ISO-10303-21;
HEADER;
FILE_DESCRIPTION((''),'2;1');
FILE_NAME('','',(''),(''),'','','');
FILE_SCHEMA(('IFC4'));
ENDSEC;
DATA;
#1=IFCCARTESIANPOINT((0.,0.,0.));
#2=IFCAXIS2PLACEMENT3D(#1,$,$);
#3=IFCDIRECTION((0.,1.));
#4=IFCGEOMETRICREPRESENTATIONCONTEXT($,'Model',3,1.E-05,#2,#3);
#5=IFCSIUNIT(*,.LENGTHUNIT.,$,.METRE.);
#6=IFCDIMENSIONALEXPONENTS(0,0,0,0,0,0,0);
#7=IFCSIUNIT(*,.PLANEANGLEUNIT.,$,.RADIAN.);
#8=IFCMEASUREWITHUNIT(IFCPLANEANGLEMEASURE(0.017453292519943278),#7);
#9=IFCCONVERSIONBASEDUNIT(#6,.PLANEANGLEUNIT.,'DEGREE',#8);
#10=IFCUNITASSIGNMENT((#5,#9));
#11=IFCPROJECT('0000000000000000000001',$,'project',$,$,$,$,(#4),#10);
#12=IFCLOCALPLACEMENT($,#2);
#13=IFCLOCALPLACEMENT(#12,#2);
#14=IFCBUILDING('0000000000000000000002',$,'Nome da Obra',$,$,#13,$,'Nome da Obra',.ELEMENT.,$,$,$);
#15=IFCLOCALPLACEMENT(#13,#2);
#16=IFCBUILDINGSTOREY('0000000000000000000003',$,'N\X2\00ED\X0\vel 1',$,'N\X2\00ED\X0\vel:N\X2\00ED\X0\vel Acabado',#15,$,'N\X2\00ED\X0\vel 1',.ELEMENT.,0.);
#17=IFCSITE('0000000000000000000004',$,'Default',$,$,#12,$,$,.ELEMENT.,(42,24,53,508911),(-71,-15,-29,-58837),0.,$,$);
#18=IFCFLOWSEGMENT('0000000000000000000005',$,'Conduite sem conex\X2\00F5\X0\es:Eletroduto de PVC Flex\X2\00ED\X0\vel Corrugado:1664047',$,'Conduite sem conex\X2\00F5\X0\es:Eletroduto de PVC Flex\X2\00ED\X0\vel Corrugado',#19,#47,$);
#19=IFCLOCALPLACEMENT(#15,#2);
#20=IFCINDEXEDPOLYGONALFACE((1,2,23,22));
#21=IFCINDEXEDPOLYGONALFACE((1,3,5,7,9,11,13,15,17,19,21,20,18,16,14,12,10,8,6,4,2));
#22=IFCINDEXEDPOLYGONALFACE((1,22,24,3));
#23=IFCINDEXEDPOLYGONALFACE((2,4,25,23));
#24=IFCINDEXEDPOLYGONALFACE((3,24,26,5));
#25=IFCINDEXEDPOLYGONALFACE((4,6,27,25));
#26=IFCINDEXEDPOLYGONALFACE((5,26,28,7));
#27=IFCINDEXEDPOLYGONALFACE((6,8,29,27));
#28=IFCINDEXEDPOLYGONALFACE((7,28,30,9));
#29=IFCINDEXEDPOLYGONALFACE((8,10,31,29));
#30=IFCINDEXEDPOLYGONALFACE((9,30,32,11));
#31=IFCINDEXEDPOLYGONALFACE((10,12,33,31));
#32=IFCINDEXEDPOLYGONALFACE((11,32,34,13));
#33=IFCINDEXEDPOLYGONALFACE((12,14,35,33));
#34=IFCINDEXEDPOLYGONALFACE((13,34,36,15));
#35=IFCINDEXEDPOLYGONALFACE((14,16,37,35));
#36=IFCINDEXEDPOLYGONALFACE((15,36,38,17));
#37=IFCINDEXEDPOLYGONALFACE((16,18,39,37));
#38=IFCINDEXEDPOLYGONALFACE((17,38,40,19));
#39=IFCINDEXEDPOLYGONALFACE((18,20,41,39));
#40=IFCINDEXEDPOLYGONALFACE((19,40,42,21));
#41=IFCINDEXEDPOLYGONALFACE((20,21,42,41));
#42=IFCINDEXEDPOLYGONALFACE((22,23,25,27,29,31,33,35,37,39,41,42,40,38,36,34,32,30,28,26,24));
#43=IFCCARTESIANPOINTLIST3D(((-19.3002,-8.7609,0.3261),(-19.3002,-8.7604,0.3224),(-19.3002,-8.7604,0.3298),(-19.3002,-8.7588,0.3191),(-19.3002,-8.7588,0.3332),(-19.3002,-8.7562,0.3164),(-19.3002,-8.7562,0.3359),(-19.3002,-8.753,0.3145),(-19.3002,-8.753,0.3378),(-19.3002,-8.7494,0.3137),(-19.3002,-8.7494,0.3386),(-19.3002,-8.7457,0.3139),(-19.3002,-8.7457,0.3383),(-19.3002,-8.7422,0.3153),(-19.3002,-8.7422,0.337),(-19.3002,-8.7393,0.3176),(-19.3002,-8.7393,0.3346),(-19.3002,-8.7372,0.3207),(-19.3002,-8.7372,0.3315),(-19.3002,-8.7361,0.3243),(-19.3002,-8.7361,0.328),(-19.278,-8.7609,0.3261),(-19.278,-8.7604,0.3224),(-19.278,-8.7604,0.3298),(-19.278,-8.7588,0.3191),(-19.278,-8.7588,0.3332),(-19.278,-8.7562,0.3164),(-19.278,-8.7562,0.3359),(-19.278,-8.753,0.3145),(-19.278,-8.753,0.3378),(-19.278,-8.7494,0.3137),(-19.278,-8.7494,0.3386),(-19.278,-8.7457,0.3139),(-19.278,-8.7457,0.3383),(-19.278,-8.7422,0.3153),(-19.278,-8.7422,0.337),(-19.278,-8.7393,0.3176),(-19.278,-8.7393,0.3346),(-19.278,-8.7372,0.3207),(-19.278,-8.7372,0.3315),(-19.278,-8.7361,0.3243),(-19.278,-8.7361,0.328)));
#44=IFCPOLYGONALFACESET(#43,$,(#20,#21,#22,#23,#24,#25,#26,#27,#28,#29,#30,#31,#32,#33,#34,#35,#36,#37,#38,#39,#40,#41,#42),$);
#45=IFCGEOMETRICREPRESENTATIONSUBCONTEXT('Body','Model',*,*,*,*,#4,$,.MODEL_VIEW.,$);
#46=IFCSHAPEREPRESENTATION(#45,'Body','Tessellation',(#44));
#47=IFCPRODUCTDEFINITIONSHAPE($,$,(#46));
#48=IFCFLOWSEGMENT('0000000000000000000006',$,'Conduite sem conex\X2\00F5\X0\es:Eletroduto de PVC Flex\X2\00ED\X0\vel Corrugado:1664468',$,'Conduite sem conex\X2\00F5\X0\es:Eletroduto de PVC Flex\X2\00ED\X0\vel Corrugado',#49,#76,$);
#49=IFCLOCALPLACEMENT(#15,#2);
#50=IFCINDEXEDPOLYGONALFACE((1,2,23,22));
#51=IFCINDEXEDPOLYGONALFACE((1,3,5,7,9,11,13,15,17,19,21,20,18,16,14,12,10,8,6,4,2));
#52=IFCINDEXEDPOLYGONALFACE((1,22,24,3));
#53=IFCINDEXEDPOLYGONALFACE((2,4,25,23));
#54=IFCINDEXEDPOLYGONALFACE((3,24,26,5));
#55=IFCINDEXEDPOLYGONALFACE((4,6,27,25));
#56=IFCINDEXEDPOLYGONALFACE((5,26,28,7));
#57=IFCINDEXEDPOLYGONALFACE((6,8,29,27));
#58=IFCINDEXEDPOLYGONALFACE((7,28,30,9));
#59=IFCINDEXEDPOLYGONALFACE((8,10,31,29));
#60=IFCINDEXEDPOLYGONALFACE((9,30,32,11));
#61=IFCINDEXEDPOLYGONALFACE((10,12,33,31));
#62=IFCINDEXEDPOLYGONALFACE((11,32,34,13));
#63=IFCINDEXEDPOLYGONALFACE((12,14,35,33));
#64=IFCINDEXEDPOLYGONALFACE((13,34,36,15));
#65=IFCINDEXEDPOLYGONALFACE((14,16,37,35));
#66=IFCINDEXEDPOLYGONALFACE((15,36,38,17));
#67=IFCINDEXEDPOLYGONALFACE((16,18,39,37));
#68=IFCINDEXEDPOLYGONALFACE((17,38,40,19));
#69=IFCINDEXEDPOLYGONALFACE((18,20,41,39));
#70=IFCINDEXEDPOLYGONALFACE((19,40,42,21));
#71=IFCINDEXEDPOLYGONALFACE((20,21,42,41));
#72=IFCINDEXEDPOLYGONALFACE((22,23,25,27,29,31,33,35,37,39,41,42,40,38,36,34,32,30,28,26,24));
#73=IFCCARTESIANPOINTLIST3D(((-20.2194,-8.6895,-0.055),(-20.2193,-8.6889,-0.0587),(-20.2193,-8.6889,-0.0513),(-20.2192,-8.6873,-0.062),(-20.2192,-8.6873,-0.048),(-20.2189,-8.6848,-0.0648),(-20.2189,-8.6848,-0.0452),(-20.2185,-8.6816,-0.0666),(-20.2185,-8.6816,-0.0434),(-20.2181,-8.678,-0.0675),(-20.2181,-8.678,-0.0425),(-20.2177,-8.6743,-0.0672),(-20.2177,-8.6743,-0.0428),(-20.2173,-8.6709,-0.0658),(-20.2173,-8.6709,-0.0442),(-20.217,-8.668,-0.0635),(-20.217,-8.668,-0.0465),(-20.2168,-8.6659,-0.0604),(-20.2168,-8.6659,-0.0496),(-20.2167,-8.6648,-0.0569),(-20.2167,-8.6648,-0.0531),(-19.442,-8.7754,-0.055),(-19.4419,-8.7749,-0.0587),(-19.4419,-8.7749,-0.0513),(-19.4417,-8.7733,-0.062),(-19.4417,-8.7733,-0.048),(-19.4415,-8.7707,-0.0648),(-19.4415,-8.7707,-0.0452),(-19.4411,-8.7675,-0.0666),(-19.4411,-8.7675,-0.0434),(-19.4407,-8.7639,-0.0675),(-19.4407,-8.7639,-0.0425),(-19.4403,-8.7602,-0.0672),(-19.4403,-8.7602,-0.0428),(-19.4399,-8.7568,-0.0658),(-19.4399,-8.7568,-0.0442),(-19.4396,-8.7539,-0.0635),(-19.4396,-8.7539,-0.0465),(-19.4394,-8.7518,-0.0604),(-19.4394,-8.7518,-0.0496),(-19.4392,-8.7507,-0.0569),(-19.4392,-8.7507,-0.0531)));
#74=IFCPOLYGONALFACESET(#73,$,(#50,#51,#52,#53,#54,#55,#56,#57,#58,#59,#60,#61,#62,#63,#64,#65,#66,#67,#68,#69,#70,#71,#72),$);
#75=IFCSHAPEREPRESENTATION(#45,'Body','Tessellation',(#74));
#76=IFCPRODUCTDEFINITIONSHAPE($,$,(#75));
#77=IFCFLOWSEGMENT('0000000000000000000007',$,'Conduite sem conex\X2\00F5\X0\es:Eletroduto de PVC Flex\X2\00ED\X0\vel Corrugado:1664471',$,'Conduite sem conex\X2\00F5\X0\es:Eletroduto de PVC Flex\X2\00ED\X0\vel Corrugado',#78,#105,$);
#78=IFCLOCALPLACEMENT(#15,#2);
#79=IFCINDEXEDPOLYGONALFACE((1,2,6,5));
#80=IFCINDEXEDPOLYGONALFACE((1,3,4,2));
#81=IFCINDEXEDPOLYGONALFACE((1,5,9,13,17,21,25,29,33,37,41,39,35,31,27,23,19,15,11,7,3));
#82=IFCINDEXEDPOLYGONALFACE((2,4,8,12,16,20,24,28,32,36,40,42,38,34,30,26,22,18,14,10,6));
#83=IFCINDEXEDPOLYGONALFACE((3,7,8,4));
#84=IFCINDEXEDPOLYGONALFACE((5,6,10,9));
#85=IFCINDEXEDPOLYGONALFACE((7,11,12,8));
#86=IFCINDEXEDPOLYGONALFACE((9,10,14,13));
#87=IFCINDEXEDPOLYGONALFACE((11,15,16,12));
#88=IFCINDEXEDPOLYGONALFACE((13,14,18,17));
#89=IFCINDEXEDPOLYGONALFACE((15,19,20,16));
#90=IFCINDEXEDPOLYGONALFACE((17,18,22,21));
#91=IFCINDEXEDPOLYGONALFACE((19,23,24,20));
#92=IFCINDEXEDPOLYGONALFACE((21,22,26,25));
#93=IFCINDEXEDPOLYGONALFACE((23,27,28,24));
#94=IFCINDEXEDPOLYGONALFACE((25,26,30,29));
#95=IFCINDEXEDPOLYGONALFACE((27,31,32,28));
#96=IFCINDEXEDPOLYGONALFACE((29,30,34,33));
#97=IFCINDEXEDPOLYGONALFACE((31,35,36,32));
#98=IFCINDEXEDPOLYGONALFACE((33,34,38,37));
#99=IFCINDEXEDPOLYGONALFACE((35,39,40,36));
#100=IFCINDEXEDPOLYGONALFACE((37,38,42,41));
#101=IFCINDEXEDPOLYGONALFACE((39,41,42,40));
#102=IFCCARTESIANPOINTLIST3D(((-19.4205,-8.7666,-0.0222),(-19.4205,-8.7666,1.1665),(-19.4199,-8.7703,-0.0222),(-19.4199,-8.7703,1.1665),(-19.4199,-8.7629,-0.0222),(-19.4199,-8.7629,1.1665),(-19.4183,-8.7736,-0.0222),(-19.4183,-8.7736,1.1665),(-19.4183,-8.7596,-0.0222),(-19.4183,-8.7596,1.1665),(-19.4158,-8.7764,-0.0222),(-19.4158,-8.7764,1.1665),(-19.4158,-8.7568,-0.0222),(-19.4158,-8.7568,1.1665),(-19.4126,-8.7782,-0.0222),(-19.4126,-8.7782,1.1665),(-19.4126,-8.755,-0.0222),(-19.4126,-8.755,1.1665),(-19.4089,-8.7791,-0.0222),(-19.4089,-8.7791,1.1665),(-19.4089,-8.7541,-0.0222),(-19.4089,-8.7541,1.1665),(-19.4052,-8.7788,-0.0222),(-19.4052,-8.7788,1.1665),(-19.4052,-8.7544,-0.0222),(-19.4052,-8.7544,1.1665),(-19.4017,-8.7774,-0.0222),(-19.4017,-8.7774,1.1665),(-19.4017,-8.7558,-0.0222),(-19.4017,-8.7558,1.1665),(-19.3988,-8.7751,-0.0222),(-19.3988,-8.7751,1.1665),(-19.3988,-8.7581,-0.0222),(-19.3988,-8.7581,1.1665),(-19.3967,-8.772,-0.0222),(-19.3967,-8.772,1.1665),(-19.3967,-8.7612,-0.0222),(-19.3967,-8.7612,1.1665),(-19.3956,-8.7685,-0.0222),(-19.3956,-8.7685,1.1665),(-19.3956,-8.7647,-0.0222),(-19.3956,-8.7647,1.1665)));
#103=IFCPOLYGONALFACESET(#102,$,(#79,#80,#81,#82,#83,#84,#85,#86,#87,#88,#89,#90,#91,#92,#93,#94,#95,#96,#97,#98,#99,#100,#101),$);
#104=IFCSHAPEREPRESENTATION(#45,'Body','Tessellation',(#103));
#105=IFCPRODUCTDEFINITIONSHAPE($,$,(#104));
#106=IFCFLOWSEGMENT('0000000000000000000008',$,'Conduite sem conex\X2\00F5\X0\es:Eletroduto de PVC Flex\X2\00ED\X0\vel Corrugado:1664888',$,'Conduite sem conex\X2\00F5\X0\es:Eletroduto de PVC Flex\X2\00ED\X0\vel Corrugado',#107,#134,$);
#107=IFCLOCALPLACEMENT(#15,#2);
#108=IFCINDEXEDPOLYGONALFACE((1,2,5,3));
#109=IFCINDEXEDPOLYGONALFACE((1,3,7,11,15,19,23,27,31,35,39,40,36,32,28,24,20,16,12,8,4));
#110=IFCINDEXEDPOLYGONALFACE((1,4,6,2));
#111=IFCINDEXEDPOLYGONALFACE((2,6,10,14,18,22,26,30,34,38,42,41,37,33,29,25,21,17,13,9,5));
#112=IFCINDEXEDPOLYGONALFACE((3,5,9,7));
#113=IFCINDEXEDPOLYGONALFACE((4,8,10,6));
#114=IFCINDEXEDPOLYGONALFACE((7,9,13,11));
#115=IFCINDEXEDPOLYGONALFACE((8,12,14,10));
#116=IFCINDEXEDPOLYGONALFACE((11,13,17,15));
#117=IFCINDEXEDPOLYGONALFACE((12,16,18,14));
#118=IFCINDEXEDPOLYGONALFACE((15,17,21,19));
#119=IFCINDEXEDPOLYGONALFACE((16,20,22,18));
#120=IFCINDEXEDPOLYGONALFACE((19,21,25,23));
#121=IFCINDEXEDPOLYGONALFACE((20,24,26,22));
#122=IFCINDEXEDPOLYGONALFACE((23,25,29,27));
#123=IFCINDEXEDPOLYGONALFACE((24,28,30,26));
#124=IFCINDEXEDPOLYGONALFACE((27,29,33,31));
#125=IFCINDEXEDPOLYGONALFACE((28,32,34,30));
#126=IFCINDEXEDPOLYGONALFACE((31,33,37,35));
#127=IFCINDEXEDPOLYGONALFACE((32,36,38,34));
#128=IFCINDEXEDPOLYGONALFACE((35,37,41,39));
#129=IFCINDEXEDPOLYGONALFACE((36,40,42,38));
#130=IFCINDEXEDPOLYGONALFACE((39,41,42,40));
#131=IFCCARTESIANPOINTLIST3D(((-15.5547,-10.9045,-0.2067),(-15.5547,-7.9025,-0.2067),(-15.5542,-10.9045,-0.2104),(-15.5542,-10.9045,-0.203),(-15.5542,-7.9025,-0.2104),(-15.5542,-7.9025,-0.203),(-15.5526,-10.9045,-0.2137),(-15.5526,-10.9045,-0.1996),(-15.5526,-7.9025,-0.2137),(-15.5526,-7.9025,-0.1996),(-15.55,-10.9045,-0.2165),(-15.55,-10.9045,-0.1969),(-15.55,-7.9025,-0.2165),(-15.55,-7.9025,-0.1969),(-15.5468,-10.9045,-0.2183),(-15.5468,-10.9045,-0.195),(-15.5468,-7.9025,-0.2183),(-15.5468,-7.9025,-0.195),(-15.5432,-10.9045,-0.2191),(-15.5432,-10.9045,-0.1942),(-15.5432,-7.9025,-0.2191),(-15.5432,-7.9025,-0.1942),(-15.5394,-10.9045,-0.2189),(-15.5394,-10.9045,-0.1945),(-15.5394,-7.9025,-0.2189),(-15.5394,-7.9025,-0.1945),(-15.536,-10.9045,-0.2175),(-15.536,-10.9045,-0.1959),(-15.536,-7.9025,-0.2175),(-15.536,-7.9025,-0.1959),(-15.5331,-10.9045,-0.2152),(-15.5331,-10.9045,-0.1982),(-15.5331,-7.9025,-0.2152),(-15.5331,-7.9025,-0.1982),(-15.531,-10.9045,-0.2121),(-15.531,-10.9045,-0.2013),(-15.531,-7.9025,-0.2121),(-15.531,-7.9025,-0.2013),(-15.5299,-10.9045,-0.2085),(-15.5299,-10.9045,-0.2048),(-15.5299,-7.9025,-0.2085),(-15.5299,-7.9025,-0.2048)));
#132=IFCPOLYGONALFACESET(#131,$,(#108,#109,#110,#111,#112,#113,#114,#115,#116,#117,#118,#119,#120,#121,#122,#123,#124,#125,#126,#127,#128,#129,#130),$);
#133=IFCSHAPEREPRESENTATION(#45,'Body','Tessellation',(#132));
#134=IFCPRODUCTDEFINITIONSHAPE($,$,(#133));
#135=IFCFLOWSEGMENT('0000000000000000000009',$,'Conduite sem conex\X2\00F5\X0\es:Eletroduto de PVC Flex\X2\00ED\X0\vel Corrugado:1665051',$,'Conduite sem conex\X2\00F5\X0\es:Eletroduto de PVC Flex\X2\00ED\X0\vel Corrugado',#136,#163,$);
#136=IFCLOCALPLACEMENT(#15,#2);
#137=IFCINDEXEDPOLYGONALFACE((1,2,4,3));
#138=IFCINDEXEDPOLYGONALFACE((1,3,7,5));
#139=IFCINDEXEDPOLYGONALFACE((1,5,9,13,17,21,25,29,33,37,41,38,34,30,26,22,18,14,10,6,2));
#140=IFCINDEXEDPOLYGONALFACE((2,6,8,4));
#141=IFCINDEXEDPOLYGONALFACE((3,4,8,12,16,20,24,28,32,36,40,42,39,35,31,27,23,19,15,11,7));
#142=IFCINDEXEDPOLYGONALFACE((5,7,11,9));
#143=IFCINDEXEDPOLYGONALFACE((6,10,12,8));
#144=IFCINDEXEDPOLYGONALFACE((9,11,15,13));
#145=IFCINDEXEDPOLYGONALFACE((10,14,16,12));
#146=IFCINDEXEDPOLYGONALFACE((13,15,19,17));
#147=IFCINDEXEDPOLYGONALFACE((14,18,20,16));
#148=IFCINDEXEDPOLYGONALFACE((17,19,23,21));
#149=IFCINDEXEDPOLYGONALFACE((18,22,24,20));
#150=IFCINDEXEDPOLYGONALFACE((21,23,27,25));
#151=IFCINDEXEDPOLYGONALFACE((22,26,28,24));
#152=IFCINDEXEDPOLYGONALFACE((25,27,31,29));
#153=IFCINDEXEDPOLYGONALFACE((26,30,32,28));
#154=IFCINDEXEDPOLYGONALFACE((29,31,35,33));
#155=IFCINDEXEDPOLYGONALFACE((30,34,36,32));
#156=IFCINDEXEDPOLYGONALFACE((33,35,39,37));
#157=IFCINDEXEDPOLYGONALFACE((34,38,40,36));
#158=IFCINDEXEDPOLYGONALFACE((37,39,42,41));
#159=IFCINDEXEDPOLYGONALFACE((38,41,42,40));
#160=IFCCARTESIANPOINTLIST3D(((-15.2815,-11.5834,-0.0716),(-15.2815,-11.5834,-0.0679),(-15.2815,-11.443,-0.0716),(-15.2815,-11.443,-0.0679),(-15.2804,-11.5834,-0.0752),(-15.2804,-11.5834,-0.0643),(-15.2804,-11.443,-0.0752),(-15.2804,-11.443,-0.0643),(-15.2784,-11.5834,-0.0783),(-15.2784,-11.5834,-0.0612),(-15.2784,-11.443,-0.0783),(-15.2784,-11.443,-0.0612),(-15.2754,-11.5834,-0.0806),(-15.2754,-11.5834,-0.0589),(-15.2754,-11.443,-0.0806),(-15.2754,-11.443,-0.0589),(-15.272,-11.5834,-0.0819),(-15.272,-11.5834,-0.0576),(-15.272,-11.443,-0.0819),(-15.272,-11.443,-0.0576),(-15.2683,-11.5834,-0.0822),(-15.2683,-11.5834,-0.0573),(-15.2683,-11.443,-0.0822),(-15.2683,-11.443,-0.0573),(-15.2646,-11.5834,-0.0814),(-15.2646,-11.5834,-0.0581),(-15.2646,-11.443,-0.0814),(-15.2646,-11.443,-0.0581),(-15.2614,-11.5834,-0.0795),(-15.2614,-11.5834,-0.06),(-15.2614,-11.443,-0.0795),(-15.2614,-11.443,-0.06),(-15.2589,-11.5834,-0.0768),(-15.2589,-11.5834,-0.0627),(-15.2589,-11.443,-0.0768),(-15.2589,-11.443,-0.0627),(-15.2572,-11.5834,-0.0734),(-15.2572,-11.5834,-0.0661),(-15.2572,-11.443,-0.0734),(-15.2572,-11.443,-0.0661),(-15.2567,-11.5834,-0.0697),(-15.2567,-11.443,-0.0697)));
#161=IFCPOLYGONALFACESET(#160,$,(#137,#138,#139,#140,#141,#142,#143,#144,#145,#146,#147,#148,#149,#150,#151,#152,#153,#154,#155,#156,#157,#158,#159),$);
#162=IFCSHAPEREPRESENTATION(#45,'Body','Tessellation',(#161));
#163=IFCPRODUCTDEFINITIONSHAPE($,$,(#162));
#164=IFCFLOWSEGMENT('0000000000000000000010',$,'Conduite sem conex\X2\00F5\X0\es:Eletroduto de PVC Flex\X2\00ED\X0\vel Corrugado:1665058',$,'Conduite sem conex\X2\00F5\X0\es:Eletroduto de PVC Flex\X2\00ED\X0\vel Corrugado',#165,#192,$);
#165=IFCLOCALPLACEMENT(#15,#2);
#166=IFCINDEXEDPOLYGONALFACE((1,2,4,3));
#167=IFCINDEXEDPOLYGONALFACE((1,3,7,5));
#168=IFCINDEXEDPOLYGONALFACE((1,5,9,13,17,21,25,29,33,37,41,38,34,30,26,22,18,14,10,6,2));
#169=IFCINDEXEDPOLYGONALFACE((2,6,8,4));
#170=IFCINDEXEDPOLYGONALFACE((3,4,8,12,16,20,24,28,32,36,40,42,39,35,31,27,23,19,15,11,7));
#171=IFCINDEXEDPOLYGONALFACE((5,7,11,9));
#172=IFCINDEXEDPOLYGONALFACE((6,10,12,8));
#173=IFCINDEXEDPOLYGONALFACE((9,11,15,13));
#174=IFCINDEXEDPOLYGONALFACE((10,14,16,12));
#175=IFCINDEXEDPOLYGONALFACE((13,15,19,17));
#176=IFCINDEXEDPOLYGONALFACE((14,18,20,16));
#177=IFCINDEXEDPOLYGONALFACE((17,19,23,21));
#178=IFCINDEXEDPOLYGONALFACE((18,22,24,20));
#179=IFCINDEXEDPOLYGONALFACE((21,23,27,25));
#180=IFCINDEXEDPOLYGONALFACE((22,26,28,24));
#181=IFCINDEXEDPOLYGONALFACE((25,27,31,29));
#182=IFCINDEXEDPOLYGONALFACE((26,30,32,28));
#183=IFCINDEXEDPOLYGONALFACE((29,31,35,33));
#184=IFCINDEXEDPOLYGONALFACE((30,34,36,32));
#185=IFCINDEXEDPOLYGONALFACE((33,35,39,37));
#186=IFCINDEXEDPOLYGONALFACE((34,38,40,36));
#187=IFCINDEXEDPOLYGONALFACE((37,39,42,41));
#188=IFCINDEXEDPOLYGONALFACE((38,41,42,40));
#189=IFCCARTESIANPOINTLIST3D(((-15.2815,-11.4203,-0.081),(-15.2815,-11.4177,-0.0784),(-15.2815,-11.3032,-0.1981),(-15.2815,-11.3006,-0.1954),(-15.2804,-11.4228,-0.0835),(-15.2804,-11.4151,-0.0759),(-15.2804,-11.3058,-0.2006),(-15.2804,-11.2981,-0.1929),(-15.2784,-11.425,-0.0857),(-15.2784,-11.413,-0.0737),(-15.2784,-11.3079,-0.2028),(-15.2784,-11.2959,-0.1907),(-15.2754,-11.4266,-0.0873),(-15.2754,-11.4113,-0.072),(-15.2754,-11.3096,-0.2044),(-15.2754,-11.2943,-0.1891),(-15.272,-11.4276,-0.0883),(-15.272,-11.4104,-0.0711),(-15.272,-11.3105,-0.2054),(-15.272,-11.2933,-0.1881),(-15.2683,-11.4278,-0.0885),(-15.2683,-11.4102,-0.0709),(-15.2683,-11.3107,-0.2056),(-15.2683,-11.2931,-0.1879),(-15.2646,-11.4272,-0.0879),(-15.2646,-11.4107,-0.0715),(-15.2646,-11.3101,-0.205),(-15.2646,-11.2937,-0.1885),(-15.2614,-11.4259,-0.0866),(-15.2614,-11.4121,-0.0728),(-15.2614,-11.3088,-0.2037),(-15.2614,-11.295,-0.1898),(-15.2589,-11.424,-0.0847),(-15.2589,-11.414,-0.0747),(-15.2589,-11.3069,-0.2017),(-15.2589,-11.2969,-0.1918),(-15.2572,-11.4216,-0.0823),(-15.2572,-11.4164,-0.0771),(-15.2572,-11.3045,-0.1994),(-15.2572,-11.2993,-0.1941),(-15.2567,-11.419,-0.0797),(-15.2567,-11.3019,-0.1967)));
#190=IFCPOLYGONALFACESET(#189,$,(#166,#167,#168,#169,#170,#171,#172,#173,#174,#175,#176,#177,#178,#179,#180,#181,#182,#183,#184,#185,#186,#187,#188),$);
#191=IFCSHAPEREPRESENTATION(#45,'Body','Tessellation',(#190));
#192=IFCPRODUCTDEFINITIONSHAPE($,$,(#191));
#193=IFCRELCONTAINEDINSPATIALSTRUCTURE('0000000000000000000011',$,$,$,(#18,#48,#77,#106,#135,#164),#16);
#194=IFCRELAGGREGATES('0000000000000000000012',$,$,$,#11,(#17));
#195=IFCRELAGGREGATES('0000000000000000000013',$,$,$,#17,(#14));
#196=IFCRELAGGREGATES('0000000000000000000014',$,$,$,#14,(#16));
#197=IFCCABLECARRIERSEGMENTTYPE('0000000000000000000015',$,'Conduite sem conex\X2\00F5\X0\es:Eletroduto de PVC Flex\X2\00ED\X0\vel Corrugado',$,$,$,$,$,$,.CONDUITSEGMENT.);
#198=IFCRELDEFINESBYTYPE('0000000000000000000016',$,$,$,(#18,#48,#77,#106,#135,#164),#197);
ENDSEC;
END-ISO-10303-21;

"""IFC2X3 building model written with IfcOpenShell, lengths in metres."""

from ifc_helpers import new_model, entity, si_unit, converted_unit, direction, frame, frame_2d, origin, origin_2d_with_axis, place, context, subcontext, project, spatial, circle, extrude, type_object, element, save


model = new_model("IFC2X3")

# Units and contexts
model_context = context("Model", 3, precision=1e-05, world=origin(), true_north=direction((0.0, 1.0)))
body_context = subcontext(model_context, "Body", "Model", "MODEL_VIEW")
ifc_project = project(units=[si_unit("LENGTHUNIT", "METRE"), converted_unit("PLANEANGLEUNIT", "DEGREE", entity("IfcPlaneAngleMeasure", 0.017453292519943278), si_unit("PLANEANGLEUNIT", "RADIAN"), dimensions=[0, 0, 0, 0, 0, 0, 0])], contexts=[model_context])

# Site, building, storey
site_placement = place(None, origin())
site = spatial("IfcSite", under=ifc_project, at=site_placement, Name="Default", CompositionType="ELEMENT", RefLatitude=(42, 24, 53, 508911), RefLongitude=(-71, -15, -29, -58837), RefElevation=0.0)
building_placement = place(site_placement, origin())
building = spatial("IfcBuilding", under=site, at=building_placement, Name="Nome da Obra", LongName="Nome da Obra", CompositionType="ELEMENT")
storey_placement = place(building_placement, origin())
storey = spatial("IfcBuildingStorey", under=building, at=storey_placement, Name="Nível 1", ObjectType="Nível:Nível Acabado", LongName="Nível 1", CompositionType="ELEMENT", Elevation=0.0)

# Flow segments
cable_carrier_segment_type = type_object("IfcCableCarrierSegmentType", Name="Conduite sem conexões:Eletroduto de PVC Flexível Corrugado", PredefinedType="CONDUITSEGMENT")
flow_segment_1_placement = place(storey_placement, origin())
element("IfcFlowSegment", 1, at=flow_segment_1_placement, inside=storey, type_object=cable_carrier_segment_type, Name="Conduite sem conexões:Eletroduto de PVC Flexível Corrugado:1664047", ObjectType="Conduite sem conexões:Eletroduto de PVC Flexível Corrugado", context=body_context, shape_type="SweptSolid", body=[
    extrude(circle(Radius=0.0125, at=origin_2d_with_axis()), frame((-19.3002, -8.7484, 0.3261), z_axis=(1.0, 0.0, 0.0), x_axis=(0.0, -1.0, 0.0)), (0.0, 0.0, 1.0), 0.0222),
])
flow_segment_2_placement = place(storey_placement, origin())
element("IfcFlowSegment", 2, at=flow_segment_2_placement, inside=storey, type_object=cable_carrier_segment_type, Name="Conduite sem conexões:Eletroduto de PVC Flexível Corrugado:1664468", ObjectType="Conduite sem conexões:Eletroduto de PVC Flexível Corrugado", context=body_context, shape_type="SweptSolid", body=[
    extrude(circle(Radius=0.0125, at=frame_2d((0.0, 0.0), x_axis=(1.0, 0.0))), frame((-20.218, -8.6771, -0.055), z_axis=(0.993949, -0.109843, 0.0), x_axis=(-0.109843, -0.993949, 0.0)), (0.0, 0.0, 1.0), 0.7822),
])
flow_segment_3_placement = place(storey_placement, origin())
element("IfcFlowSegment", 3, at=flow_segment_3_placement, inside=storey, type_object=cable_carrier_segment_type, Name="Conduite sem conexões:Eletroduto de PVC Flexível Corrugado:1664471", ObjectType="Conduite sem conexões:Eletroduto de PVC Flexível Corrugado", context=body_context, shape_type="SweptSolid", body=[
    extrude(circle(Radius=0.0125, at=frame_2d((0.0, 0.0), x_axis=(1.0, 0.0))), frame((-19.408, -8.7666, -0.0222), z_axis=(0.0, 0.0, 1.0), x_axis=(-1.0, 0.0, 0.0)), (0.0, 0.0, 1.0), 1.1887),
])
flow_segment_4_placement = place(storey_placement, origin())
element("IfcFlowSegment", 4, at=flow_segment_4_placement, inside=storey, type_object=cable_carrier_segment_type, Name="Conduite sem conexões:Eletroduto de PVC Flexível Corrugado:1664888", ObjectType="Conduite sem conexões:Eletroduto de PVC Flexível Corrugado", context=body_context, shape_type="SweptSolid", body=[
    extrude(circle(Radius=0.0125, at=frame_2d((0.0, 0.0), x_axis=(1.0, 0.0))), frame((-15.5422, -10.9045, -0.2067), z_axis=(0.0, 1.0, 0.0), x_axis=(-1.0, 0.0, 0.0)), (0.0, 0.0, 1.0), 3.002),
])
flow_segment_5_placement = place(storey_placement, origin())
element("IfcFlowSegment", 5, at=flow_segment_5_placement, inside=storey, type_object=cable_carrier_segment_type, Name="Conduite sem conexões:Eletroduto de PVC Flexível Corrugado:1665051", ObjectType="Conduite sem conexões:Eletroduto de PVC Flexível Corrugado", context=body_context, shape_type="SweptSolid", body=[
    extrude(circle(Radius=0.0125, at=frame_2d((0.0, 0.0), x_axis=(1.0, 0.0))), frame((-15.2692, -11.5834, -0.0697), z_axis=(0.0, 1.0, 0.0), x_axis=(1.0, 0.0, 0.0)), (0.0, 0.0, 1.0), 0.1404),
])
flow_segment_6_placement = place(storey_placement, origin())
element("IfcFlowSegment", 6, at=flow_segment_6_placement, inside=storey, type_object=cable_carrier_segment_type, Name="Conduite sem conexões:Eletroduto de PVC Flexível Corrugado:1665058", ObjectType="Conduite sem conexões:Eletroduto de PVC Flexível Corrugado", context=body_context, shape_type="SweptSolid", body=[
    extrude(circle(Radius=0.0125, at=origin_2d_with_axis()), frame((-15.2692, -11.3019, -0.1967), z_axis=(0.0, -0.707107, 0.707107), x_axis=(1.0, 0.0, 0.0)), (0.0, 0.0, 1.0), 0.1655),
])

save(model, "model.ifc")
